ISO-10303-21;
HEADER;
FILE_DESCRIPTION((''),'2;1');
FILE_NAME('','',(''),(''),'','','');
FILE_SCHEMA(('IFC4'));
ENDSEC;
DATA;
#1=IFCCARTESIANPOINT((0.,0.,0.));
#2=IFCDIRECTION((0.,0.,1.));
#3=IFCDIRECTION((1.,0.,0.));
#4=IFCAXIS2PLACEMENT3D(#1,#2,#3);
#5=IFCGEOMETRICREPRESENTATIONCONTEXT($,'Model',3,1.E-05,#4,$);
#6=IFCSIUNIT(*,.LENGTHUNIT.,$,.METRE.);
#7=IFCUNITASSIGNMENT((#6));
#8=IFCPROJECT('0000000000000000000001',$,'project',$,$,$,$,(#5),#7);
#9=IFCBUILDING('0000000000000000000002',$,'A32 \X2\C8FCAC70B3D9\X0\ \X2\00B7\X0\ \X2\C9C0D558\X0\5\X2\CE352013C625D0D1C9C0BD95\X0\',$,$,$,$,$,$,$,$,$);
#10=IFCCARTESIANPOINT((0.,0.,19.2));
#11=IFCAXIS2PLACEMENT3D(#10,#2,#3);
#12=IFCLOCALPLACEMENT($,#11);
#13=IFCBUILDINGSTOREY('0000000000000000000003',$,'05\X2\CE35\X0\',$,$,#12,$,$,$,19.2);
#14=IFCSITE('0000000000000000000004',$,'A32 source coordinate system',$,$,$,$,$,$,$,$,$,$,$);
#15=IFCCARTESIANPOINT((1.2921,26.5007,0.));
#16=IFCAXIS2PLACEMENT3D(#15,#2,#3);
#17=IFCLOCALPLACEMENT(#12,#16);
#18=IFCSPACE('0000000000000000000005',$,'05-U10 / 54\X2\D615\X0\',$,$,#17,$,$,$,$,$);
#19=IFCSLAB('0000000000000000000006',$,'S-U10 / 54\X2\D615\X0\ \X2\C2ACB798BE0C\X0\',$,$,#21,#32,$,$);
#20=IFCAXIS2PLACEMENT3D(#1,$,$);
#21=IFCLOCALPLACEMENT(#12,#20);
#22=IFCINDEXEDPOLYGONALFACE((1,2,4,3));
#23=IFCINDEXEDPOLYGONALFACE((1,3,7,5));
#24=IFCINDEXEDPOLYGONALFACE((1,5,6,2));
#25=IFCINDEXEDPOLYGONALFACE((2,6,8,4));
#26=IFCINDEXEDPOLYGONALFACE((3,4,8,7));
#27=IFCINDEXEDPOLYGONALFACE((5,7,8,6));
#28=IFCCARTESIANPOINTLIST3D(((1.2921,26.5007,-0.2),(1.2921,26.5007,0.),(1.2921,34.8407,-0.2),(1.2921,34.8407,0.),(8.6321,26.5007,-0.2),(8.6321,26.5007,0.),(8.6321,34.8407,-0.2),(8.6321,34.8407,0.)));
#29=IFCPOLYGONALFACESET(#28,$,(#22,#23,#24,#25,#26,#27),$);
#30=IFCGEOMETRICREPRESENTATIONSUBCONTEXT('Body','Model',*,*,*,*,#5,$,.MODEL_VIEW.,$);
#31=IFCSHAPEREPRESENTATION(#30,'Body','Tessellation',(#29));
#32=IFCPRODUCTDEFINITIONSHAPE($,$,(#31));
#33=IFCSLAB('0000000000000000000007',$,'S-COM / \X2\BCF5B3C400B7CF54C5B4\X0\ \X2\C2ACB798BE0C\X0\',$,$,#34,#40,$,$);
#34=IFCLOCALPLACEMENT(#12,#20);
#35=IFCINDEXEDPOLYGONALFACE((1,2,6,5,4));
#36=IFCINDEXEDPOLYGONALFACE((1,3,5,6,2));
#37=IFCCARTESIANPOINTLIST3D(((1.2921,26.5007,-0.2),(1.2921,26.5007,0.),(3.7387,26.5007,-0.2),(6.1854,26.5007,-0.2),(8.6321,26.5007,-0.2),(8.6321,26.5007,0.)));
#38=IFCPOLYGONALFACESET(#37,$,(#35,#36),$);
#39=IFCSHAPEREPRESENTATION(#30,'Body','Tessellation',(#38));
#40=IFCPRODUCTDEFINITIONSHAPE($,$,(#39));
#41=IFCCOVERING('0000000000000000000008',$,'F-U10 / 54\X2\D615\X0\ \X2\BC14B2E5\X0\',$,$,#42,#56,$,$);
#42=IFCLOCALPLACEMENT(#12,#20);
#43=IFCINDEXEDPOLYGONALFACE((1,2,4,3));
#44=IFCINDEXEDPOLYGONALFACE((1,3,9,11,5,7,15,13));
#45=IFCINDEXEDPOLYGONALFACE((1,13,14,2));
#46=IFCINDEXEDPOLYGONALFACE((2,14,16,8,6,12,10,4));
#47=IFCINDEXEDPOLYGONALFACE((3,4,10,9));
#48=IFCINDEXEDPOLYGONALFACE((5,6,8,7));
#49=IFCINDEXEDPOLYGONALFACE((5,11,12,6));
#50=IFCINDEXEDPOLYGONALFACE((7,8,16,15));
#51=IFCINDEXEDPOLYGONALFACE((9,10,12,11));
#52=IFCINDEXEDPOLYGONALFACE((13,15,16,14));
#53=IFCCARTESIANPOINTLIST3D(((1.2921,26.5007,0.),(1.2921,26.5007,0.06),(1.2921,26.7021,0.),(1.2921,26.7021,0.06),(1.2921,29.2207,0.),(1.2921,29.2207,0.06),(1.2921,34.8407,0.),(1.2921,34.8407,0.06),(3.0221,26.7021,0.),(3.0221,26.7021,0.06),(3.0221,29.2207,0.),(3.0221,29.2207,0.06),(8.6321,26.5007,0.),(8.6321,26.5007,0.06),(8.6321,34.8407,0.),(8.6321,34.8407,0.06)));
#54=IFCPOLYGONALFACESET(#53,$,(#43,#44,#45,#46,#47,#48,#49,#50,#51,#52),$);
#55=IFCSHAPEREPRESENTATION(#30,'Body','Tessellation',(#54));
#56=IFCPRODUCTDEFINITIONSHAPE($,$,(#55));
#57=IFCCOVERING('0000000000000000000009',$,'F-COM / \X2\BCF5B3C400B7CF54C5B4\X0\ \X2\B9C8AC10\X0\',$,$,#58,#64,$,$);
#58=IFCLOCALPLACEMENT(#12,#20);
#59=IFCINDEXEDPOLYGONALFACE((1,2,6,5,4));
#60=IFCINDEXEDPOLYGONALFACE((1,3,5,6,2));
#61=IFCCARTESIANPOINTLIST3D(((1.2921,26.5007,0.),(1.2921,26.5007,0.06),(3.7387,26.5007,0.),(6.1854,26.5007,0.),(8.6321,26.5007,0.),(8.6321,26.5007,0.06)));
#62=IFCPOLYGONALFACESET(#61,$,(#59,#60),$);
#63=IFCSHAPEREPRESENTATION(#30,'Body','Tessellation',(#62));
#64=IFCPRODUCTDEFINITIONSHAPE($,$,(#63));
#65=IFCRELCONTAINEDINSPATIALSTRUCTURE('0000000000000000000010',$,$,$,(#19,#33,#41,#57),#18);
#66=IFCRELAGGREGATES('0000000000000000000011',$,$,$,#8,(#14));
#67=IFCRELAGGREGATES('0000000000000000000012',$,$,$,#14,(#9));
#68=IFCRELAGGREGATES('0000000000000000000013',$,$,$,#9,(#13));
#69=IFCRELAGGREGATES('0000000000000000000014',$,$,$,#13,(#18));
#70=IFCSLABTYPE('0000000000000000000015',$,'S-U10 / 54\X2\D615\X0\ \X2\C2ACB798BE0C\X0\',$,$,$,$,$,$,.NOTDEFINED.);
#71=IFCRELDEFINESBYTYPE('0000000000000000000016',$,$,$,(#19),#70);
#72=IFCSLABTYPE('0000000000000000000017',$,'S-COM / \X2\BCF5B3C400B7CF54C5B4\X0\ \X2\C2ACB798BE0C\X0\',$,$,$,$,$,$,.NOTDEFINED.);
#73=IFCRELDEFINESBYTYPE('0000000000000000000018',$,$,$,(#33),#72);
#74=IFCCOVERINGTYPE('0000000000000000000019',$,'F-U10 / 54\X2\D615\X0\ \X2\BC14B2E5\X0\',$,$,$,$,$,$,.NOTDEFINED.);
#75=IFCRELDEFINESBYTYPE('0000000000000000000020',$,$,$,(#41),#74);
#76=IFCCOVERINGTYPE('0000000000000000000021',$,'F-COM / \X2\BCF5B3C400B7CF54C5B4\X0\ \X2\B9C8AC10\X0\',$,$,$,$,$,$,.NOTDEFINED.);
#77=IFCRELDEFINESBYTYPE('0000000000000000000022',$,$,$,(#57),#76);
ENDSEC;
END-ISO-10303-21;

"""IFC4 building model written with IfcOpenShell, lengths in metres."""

from ifc_helpers import new_model, si_unit, frame, origin, origin_with_axes, place, context, subcontext, project, spatial, polyline, outline, extrude, source, transform, mapped, type_object, type_shapes, element, save


model = new_model("IFC4")

# Units and contexts
model_context = context("Model", 3, precision=1e-05, world=origin_with_axes())
body_context = subcontext(model_context, "Body", "Model", "MODEL_VIEW")
ifc_project = project(units=[si_unit("LENGTHUNIT", "METRE")], contexts=[model_context])

# Site, building, storey, space
storey_placement = place(None, frame((0.0, 0.0, 19.2), z_axis=(0.0, 0.0, 1.0), x_axis=(1.0, 0.0, 0.0)))
space_placement = place(storey_placement, frame((1.2921, 26.5007, 0.0), z_axis=(0.0, 0.0, 1.0), x_axis=(1.0, 0.0, 0.0)))
site = spatial("IfcSite", under=ifc_project, Name="A32 source coordinate system")
building = spatial("IfcBuilding", under=site, Name="A32 주거동 · 지하5층–옥탑지붕")
storey = spatial("IfcBuildingStorey", under=building, at=storey_placement, Name="05층", Elevation=19.2)
space = spatial("IfcSpace", under=storey, at=space_placement, Name="05-U10 / 54형")

# Slabs
slab_type_1 = type_object("IfcSlabType", Name="S-U10 / 54형 슬래브", PredefinedType="NOTDEFINED")
shared_shape_1 = source(origin(), body_context, "Body", "SweptSolid", [
    extrude(outline(polyline([(0.0, 0.0), (0.0, 8.34), (7.34, 8.34), (7.34, 0.0), (0.0, 0.0)])), frame((0.0, 0.0, -0.2)), (0.0, 0.0, 1.0), 0.2),
])
type_shapes(slab_type_1, [shared_shape_1])
slab_1_placement = place(space_placement, origin_with_axes())
element("IfcSlab", 1, at=slab_1_placement, inside=space, type_object=slab_type_1, Name="S-U10 / 54형 슬래브", context=body_context, shape_type="MappedRepresentation", body=[
    mapped(shared_shape_1, transform((0.0, 0.0, 0.0), scale=1.0)),
])
slab_type_2 = type_object("IfcSlabType", Name="S-COM / 복도·코어 슬래브", PredefinedType="NOTDEFINED")
shared_shape_2 = source(origin(), body_context, "Body", "SweptSolid", [
    extrude(outline(polyline([(7.34, 0.0), (7.34, 0.0), (0.0, 0.0), (0.0, 0.0), (7.34, 0.0)])), frame((0.0, 0.0, -0.2)), (0.0, 0.0, 1.0), 0.2),
])
type_shapes(slab_type_2, [shared_shape_2])
slab_2_placement = place(space_placement, origin_with_axes())
element("IfcSlab", 2, at=slab_2_placement, inside=space, type_object=slab_type_2, Name="S-COM / 복도·코어 슬래브", context=body_context, shape_type="MappedRepresentation", body=[
    mapped(shared_shape_2, transform((0.0, 0.0, 0.0), scale=1.0)),
])

# Coverings
covering_type_1 = type_object("IfcCoveringType", Name="F-U10 / 54형 바닥", PredefinedType="NOTDEFINED")
shared_shape_3 = source(origin(), body_context, "Body", "SweptSolid", [
    extrude(outline(polyline([(7.34, 0.0), (0.0, 0.0), (0.0, 0.2014), (1.73, 0.2014), (1.73, 2.72), (0.0, 2.72), (0.0, 8.34), (7.34, 8.34), (7.34, 0.0)])), origin(), (0.0, 0.0, 1.0), 0.06),
])
type_shapes(covering_type_1, [shared_shape_3])
covering_1_placement = place(space_placement, origin_with_axes())
element("IfcCovering", 3, at=covering_1_placement, inside=space, type_object=covering_type_1, Name="F-U10 / 54형 바닥", context=body_context, shape_type="MappedRepresentation", body=[
    mapped(shared_shape_3, transform((0.0, 0.0, 0.0), scale=1.0)),
])
covering_type_2 = type_object("IfcCoveringType", Name="F-COM / 복도·코어 마감", PredefinedType="NOTDEFINED")
shared_shape_4 = source(origin(), body_context, "Body", "SweptSolid", [
    extrude(outline(polyline([(7.34, 0.0), (7.34, 0.0), (0.0, 0.0), (0.0, 0.0), (7.34, 0.0)])), origin(), (0.0, 0.0, 1.0), 0.06),
])
type_shapes(covering_type_2, [shared_shape_4])
covering_2_placement = place(space_placement, origin_with_axes())
element("IfcCovering", 4, at=covering_2_placement, inside=space, type_object=covering_type_2, Name="F-COM / 복도·코어 마감", context=body_context, shape_type="MappedRepresentation", body=[
    mapped(shared_shape_4, transform((0.0, 0.0, 0.0), scale=1.0)),
])

save(model, "model.ifc")
